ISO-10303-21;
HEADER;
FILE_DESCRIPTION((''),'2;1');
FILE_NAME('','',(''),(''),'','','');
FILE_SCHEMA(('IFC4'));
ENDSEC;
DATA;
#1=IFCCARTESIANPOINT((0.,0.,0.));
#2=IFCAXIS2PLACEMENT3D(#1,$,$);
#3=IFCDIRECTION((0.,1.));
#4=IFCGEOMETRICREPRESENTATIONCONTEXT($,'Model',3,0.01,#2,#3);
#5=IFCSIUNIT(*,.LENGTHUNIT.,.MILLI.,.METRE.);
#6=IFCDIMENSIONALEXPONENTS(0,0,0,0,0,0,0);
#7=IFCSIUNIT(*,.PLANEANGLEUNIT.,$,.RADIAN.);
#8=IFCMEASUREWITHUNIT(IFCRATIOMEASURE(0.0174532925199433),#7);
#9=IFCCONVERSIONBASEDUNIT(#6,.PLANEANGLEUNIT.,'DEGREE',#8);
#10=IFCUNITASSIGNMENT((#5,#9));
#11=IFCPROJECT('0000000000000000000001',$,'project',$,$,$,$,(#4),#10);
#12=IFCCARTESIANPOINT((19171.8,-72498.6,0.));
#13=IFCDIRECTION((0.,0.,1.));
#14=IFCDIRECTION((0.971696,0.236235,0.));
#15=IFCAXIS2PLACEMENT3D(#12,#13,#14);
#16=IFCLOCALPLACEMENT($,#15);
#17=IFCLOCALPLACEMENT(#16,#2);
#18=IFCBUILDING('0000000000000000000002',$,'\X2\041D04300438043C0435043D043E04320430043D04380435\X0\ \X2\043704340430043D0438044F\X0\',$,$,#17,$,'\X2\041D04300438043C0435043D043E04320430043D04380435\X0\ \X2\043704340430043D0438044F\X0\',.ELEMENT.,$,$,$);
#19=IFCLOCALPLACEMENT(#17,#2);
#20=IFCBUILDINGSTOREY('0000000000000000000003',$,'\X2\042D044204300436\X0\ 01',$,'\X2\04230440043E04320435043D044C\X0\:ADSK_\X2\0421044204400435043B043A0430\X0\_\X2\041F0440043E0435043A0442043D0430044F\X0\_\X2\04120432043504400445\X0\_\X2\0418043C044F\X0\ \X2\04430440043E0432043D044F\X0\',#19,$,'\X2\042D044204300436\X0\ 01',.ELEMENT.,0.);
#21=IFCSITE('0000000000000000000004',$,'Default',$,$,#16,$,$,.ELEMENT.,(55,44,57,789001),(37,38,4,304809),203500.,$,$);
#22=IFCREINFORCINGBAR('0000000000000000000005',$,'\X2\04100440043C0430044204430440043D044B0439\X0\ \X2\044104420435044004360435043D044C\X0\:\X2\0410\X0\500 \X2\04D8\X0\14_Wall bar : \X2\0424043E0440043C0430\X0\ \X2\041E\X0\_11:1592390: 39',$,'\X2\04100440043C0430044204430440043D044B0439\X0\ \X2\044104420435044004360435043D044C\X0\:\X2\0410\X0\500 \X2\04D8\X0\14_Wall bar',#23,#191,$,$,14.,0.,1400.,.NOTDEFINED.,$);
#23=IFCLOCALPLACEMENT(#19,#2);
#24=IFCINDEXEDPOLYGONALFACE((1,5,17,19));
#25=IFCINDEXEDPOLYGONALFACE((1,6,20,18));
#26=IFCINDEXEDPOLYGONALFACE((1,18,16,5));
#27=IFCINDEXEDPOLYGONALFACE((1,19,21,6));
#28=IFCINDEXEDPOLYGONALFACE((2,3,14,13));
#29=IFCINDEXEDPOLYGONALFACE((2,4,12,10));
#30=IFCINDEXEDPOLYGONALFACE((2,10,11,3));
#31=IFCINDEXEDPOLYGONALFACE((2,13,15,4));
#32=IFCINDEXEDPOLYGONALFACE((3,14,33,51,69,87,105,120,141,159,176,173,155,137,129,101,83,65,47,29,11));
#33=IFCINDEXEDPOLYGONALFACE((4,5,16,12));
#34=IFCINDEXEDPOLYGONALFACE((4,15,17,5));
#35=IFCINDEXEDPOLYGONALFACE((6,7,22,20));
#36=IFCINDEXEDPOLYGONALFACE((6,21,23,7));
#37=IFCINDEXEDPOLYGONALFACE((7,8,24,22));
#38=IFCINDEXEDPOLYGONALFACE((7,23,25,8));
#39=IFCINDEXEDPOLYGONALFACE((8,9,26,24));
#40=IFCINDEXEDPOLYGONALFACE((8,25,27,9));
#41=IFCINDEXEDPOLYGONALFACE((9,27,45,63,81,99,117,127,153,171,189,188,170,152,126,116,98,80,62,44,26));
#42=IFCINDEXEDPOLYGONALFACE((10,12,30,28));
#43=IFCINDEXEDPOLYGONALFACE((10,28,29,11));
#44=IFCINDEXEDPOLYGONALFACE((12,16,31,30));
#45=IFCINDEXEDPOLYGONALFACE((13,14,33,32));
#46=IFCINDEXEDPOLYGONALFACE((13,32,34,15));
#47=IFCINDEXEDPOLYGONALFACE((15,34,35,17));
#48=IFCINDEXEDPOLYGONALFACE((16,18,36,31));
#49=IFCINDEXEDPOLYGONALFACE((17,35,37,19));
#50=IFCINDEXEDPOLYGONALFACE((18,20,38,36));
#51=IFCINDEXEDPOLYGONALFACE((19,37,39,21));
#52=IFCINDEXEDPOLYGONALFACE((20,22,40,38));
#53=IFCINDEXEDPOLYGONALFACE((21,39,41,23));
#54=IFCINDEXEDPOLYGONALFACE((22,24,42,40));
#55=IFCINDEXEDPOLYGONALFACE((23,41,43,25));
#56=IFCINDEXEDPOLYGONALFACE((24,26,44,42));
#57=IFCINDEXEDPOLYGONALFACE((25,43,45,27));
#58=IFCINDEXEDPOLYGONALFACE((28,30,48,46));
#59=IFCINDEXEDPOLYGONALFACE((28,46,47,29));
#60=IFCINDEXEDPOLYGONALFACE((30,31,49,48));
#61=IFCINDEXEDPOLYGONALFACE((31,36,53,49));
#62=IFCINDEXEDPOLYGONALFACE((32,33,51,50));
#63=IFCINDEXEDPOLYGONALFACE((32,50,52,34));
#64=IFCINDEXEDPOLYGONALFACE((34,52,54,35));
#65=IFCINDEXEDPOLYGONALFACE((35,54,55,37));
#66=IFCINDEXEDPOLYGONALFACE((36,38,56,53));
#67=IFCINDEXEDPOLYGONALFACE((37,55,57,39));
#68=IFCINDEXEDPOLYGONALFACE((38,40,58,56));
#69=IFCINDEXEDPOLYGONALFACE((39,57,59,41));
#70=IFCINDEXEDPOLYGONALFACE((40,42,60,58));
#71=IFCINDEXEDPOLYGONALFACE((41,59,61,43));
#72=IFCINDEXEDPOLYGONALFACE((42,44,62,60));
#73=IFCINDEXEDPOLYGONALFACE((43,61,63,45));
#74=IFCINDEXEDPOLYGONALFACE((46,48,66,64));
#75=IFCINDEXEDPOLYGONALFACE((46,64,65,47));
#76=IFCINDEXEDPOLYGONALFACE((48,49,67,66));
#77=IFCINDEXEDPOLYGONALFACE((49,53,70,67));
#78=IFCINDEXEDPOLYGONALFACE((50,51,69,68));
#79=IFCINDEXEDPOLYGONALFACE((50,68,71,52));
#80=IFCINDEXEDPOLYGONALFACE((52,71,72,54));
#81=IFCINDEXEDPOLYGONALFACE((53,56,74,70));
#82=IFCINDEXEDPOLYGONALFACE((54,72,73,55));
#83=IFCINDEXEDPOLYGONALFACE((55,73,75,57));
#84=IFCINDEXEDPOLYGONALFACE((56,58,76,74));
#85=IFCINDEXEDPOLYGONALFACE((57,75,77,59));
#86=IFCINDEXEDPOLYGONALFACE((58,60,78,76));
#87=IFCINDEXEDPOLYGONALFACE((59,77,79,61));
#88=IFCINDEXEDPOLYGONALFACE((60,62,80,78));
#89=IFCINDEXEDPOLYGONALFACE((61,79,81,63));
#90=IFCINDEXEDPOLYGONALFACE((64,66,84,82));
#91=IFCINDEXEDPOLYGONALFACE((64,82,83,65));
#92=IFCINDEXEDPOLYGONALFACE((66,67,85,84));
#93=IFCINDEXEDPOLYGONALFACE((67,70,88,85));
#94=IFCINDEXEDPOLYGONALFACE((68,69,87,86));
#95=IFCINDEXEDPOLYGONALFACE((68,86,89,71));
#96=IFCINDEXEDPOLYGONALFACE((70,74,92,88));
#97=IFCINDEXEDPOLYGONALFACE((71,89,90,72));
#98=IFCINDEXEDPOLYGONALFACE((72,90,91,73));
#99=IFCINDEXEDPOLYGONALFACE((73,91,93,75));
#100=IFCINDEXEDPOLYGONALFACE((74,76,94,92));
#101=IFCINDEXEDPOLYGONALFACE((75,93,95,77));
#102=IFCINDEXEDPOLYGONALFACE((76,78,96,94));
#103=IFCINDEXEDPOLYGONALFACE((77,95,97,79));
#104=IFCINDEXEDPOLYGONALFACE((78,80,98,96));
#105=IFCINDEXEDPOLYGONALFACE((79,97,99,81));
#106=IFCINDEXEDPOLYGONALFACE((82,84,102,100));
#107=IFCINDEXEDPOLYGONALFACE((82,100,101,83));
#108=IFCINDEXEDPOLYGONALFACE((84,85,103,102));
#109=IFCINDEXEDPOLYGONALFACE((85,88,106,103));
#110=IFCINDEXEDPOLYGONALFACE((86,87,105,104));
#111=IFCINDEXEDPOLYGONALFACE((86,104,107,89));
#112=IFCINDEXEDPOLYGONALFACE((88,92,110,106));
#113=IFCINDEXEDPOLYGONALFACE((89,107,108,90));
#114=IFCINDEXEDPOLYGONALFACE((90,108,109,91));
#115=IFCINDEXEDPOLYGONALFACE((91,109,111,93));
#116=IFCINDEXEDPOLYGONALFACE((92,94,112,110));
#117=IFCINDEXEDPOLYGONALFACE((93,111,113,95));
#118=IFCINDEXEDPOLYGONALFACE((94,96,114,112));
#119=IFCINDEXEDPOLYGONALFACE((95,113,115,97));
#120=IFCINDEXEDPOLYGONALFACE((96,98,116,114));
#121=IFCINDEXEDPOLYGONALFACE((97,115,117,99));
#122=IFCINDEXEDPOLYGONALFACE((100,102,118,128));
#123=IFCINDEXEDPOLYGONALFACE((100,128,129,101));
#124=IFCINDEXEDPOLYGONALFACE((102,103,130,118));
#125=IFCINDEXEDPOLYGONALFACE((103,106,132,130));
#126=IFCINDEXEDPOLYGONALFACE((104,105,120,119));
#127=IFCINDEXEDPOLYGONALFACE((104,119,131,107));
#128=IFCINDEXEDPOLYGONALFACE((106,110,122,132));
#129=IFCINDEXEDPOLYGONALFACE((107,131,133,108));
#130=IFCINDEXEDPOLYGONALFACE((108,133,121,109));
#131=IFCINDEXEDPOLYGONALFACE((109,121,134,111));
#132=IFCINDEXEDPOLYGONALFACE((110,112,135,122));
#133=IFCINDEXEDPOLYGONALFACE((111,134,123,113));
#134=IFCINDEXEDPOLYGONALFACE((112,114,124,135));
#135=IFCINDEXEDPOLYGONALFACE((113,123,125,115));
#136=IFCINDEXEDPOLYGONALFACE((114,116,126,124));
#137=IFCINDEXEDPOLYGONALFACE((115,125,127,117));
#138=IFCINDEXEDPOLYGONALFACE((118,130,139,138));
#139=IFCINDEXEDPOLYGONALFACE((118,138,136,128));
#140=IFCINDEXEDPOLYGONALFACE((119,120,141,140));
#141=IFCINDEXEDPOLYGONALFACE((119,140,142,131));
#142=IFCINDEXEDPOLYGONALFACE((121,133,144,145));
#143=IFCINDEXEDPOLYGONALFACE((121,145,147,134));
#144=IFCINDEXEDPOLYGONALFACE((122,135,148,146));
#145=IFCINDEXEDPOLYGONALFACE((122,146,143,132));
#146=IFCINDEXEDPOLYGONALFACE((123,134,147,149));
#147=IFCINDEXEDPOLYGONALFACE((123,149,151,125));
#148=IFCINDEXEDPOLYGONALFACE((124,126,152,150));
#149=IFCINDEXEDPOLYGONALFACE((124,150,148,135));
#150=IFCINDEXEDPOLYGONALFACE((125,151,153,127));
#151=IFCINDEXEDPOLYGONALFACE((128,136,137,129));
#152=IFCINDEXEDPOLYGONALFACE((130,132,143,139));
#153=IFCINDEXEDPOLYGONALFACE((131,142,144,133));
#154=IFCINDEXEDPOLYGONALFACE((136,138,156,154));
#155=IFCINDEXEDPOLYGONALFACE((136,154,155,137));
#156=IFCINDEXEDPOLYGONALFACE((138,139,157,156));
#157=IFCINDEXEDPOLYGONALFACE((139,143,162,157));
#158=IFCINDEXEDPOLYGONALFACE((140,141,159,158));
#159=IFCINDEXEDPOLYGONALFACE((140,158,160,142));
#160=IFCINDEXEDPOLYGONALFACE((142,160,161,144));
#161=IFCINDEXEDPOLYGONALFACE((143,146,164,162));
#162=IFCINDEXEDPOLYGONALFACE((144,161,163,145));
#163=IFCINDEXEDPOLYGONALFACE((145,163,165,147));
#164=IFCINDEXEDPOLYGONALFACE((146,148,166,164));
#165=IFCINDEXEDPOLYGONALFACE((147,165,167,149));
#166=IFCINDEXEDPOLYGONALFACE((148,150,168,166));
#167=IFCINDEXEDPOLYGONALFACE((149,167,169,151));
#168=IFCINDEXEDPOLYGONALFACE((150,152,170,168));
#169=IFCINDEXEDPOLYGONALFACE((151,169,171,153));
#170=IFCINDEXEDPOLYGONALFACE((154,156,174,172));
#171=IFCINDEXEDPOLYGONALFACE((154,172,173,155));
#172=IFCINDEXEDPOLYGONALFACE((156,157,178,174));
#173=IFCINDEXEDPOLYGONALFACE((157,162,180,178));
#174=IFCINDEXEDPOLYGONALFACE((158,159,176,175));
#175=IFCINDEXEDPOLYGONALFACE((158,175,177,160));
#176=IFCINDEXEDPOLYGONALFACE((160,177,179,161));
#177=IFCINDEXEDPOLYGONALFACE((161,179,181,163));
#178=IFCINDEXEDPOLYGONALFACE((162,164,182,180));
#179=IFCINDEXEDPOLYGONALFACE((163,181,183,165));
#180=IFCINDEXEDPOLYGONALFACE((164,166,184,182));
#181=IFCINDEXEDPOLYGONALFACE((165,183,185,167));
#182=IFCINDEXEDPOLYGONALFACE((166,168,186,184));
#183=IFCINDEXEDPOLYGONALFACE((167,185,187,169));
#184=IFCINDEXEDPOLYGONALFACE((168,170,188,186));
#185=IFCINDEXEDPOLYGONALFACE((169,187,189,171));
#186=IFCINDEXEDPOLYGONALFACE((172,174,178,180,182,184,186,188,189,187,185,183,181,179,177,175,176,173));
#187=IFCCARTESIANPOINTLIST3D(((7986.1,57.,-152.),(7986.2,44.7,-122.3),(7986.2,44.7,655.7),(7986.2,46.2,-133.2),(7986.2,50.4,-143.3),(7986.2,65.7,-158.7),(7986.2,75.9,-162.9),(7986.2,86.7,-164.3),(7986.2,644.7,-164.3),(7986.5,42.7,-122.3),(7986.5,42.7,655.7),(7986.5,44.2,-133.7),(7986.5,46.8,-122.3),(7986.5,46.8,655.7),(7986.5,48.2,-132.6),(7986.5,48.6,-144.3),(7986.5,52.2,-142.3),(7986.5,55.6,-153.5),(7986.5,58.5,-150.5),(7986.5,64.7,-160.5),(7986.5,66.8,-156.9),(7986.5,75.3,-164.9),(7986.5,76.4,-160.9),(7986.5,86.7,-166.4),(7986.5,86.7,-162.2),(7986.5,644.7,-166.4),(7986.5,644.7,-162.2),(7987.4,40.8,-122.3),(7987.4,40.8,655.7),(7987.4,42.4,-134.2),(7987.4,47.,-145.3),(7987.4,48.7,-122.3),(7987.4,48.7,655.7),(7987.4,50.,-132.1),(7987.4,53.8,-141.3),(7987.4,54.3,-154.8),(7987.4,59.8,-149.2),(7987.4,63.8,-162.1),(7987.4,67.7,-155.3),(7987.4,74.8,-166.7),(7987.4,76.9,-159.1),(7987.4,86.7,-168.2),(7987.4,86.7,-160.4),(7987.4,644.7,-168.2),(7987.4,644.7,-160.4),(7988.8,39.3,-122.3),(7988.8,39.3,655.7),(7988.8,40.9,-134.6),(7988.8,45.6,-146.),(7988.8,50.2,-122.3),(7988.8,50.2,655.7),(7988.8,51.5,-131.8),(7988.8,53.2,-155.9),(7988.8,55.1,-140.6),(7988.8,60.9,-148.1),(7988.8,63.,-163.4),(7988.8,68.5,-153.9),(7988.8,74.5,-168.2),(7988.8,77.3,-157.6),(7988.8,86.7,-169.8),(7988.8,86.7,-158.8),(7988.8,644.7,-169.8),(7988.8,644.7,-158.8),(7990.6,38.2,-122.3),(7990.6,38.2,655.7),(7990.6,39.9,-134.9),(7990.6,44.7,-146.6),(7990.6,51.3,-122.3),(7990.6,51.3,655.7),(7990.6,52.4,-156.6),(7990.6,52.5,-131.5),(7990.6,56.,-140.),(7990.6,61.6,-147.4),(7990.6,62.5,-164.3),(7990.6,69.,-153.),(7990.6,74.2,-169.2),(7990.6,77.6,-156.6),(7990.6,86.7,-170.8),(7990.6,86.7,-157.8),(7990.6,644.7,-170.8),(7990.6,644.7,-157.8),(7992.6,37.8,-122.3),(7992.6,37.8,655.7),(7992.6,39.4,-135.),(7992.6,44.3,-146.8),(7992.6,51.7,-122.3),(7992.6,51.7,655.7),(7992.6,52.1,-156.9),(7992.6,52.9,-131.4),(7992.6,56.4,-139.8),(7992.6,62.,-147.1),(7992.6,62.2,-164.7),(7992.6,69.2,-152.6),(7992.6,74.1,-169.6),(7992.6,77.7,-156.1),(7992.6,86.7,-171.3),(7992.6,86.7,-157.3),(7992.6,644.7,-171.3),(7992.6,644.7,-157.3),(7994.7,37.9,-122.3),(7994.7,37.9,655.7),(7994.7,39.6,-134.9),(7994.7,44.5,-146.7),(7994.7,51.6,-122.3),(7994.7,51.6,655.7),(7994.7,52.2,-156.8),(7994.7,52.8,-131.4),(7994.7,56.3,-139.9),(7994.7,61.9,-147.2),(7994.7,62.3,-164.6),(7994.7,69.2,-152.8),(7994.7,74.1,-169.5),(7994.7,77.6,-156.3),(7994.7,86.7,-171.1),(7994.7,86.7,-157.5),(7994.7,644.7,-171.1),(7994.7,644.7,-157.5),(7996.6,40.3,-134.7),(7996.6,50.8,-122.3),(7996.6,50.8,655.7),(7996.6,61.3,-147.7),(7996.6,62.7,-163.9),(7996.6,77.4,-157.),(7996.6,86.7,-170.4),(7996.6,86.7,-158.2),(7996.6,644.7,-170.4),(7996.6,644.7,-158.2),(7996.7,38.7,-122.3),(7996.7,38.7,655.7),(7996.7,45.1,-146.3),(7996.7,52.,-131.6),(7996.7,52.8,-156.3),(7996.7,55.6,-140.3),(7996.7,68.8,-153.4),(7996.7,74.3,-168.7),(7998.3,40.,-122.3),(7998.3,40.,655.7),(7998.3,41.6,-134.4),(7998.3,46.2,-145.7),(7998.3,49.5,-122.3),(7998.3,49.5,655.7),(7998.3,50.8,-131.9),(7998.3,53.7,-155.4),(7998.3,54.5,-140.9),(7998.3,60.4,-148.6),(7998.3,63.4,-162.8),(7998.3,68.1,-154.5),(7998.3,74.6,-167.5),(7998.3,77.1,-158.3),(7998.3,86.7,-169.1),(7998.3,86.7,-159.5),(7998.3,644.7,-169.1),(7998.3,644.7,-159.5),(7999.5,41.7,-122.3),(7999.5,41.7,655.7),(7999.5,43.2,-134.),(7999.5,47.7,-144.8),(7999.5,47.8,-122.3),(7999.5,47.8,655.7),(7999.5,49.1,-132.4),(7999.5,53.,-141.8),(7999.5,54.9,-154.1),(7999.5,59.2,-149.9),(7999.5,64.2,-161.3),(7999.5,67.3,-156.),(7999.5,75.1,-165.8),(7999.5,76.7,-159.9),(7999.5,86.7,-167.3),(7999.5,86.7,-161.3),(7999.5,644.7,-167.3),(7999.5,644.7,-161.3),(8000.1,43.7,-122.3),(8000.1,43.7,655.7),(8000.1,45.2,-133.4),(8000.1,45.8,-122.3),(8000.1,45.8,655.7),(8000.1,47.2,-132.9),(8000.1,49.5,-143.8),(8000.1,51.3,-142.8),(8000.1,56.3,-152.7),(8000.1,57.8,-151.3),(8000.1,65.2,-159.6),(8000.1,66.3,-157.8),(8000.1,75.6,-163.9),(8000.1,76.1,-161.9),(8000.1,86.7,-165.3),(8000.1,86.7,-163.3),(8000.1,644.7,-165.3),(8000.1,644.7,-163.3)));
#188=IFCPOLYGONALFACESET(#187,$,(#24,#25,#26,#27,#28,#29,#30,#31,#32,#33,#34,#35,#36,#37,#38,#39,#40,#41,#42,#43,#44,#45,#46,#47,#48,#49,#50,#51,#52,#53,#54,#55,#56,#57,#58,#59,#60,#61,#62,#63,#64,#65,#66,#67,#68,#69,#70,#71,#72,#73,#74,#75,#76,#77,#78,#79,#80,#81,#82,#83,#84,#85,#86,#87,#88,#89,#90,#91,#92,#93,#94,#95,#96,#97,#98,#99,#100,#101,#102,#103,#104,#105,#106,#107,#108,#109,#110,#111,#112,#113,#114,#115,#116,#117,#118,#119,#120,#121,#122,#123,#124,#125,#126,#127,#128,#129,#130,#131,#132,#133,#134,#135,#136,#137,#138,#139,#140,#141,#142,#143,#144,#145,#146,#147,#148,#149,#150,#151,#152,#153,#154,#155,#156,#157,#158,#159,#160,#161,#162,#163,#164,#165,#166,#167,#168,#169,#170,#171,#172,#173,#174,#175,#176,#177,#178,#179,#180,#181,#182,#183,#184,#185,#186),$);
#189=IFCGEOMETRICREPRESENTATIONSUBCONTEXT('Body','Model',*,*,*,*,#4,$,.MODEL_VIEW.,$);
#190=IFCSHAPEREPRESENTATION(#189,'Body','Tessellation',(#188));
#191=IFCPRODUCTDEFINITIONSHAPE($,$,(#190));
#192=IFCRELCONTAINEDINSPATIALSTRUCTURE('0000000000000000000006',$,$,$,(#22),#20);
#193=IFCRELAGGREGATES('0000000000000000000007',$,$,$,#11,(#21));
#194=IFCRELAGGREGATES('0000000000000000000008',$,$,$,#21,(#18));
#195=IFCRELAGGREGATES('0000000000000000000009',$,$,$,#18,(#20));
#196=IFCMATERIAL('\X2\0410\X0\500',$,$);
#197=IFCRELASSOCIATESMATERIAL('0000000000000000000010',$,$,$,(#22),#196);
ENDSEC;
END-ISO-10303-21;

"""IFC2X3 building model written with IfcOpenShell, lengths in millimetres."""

from ifc_helpers import new_model, entity, si_unit, converted_unit, direction, frame, origin, place, context, subcontext, project, spatial, material, element, save


model = new_model("IFC2X3")

# Units and contexts
model_context = context("Model", 3, precision=0.01, world=origin(), true_north=direction((0.0, 1.0)))
body_context = subcontext(model_context, "Body", "Model", "MODEL_VIEW")
ifc_project = project(units=[si_unit("LENGTHUNIT", "METRE", prefix="MILLI"), converted_unit("PLANEANGLEUNIT", "DEGREE", entity("IfcRatioMeasure", 0.0174532925199433), si_unit("PLANEANGLEUNIT", "RADIAN"), dimensions=[0, 0, 0, 0, 0, 0, 0])], contexts=[model_context])

# Site, building, storey
site_placement = place(None, frame((19171.8, -72498.6, 0.0), z_axis=(0.0, 0.0, 1.0), x_axis=(0.971696, 0.236235, 0.0)))
site = spatial("IfcSite", under=ifc_project, at=site_placement, Name="Default", CompositionType="ELEMENT", RefLatitude=(55, 44, 57, 789001), RefLongitude=(37, 38, 4, 304809), RefElevation=203500.0)
building_placement = place(site_placement, origin())
building = spatial("IfcBuilding", under=site, at=building_placement, Name="Наименование здания", LongName="Наименование здания", CompositionType="ELEMENT")
storey_placement = place(building_placement, origin())
storey = spatial("IfcBuildingStorey", under=building, at=storey_placement, Name="Этаж 01", ObjectType="Уровень:ADSK_Стрелка_Проектная_Вверх_Имя уровня", LongName="Этаж 01", CompositionType="ELEMENT", Elevation=0.0)

# Reinforcing bar
ifc_material = material(Name="А500")
placement = place(storey_placement, origin())
element("IfcReinforcingBar", 1, at=placement, inside=storey, material=ifc_material, Name="Арматурный стержень:А500 Ә14_Wall bar : Форма О_11:1592390: 39", ObjectType="Арматурный стержень:А500 Ә14_Wall bar", BarLength=1400.0, BarRole="NOTDEFINED", CrossSectionArea=0.0, NominalDiameter=14.0, context=body_context, shape_type="AdvancedSweptSolid", body=[
    entity("IfcSweptDiskSolid", entity("IfcCompositeCurve", [entity("IfcCompositeCurveSegment", "CONTINUOUS", True, entity("IfcPolyline", [entity("IfcCartesianPoint", [7993.1, 44.7, 655.7]), entity("IfcCartesianPoint", [7993.1, 44.7, -122.3])])), entity("IfcCompositeCurveSegment", "CONTINUOUS", True, entity("IfcTrimmedCurve", entity("IfcCircle", entity("IfcAxis2Placement3D", entity("IfcCartesianPoint", [7993.1, 86.7, -122.3]), entity("IfcDirection", [1.0, 0.0, 0.0]), entity("IfcDirection", [0.0, 0.0, -1.0])), 42.0), [entity("IfcParameterValue", 270.0)], [entity("IfcParameterValue", 360.0)], True, "PARAMETER")), entity("IfcCompositeCurveSegment", "CONTINUOUS", True, entity("IfcPolyline", [entity("IfcCartesianPoint", [7993.1, 86.7, -164.3]), entity("IfcCartesianPoint", [7993.1, 644.7, -164.3])]))], False), 7.0, None, 0.0, 92.0),
])

save(model, "model.ifc")
